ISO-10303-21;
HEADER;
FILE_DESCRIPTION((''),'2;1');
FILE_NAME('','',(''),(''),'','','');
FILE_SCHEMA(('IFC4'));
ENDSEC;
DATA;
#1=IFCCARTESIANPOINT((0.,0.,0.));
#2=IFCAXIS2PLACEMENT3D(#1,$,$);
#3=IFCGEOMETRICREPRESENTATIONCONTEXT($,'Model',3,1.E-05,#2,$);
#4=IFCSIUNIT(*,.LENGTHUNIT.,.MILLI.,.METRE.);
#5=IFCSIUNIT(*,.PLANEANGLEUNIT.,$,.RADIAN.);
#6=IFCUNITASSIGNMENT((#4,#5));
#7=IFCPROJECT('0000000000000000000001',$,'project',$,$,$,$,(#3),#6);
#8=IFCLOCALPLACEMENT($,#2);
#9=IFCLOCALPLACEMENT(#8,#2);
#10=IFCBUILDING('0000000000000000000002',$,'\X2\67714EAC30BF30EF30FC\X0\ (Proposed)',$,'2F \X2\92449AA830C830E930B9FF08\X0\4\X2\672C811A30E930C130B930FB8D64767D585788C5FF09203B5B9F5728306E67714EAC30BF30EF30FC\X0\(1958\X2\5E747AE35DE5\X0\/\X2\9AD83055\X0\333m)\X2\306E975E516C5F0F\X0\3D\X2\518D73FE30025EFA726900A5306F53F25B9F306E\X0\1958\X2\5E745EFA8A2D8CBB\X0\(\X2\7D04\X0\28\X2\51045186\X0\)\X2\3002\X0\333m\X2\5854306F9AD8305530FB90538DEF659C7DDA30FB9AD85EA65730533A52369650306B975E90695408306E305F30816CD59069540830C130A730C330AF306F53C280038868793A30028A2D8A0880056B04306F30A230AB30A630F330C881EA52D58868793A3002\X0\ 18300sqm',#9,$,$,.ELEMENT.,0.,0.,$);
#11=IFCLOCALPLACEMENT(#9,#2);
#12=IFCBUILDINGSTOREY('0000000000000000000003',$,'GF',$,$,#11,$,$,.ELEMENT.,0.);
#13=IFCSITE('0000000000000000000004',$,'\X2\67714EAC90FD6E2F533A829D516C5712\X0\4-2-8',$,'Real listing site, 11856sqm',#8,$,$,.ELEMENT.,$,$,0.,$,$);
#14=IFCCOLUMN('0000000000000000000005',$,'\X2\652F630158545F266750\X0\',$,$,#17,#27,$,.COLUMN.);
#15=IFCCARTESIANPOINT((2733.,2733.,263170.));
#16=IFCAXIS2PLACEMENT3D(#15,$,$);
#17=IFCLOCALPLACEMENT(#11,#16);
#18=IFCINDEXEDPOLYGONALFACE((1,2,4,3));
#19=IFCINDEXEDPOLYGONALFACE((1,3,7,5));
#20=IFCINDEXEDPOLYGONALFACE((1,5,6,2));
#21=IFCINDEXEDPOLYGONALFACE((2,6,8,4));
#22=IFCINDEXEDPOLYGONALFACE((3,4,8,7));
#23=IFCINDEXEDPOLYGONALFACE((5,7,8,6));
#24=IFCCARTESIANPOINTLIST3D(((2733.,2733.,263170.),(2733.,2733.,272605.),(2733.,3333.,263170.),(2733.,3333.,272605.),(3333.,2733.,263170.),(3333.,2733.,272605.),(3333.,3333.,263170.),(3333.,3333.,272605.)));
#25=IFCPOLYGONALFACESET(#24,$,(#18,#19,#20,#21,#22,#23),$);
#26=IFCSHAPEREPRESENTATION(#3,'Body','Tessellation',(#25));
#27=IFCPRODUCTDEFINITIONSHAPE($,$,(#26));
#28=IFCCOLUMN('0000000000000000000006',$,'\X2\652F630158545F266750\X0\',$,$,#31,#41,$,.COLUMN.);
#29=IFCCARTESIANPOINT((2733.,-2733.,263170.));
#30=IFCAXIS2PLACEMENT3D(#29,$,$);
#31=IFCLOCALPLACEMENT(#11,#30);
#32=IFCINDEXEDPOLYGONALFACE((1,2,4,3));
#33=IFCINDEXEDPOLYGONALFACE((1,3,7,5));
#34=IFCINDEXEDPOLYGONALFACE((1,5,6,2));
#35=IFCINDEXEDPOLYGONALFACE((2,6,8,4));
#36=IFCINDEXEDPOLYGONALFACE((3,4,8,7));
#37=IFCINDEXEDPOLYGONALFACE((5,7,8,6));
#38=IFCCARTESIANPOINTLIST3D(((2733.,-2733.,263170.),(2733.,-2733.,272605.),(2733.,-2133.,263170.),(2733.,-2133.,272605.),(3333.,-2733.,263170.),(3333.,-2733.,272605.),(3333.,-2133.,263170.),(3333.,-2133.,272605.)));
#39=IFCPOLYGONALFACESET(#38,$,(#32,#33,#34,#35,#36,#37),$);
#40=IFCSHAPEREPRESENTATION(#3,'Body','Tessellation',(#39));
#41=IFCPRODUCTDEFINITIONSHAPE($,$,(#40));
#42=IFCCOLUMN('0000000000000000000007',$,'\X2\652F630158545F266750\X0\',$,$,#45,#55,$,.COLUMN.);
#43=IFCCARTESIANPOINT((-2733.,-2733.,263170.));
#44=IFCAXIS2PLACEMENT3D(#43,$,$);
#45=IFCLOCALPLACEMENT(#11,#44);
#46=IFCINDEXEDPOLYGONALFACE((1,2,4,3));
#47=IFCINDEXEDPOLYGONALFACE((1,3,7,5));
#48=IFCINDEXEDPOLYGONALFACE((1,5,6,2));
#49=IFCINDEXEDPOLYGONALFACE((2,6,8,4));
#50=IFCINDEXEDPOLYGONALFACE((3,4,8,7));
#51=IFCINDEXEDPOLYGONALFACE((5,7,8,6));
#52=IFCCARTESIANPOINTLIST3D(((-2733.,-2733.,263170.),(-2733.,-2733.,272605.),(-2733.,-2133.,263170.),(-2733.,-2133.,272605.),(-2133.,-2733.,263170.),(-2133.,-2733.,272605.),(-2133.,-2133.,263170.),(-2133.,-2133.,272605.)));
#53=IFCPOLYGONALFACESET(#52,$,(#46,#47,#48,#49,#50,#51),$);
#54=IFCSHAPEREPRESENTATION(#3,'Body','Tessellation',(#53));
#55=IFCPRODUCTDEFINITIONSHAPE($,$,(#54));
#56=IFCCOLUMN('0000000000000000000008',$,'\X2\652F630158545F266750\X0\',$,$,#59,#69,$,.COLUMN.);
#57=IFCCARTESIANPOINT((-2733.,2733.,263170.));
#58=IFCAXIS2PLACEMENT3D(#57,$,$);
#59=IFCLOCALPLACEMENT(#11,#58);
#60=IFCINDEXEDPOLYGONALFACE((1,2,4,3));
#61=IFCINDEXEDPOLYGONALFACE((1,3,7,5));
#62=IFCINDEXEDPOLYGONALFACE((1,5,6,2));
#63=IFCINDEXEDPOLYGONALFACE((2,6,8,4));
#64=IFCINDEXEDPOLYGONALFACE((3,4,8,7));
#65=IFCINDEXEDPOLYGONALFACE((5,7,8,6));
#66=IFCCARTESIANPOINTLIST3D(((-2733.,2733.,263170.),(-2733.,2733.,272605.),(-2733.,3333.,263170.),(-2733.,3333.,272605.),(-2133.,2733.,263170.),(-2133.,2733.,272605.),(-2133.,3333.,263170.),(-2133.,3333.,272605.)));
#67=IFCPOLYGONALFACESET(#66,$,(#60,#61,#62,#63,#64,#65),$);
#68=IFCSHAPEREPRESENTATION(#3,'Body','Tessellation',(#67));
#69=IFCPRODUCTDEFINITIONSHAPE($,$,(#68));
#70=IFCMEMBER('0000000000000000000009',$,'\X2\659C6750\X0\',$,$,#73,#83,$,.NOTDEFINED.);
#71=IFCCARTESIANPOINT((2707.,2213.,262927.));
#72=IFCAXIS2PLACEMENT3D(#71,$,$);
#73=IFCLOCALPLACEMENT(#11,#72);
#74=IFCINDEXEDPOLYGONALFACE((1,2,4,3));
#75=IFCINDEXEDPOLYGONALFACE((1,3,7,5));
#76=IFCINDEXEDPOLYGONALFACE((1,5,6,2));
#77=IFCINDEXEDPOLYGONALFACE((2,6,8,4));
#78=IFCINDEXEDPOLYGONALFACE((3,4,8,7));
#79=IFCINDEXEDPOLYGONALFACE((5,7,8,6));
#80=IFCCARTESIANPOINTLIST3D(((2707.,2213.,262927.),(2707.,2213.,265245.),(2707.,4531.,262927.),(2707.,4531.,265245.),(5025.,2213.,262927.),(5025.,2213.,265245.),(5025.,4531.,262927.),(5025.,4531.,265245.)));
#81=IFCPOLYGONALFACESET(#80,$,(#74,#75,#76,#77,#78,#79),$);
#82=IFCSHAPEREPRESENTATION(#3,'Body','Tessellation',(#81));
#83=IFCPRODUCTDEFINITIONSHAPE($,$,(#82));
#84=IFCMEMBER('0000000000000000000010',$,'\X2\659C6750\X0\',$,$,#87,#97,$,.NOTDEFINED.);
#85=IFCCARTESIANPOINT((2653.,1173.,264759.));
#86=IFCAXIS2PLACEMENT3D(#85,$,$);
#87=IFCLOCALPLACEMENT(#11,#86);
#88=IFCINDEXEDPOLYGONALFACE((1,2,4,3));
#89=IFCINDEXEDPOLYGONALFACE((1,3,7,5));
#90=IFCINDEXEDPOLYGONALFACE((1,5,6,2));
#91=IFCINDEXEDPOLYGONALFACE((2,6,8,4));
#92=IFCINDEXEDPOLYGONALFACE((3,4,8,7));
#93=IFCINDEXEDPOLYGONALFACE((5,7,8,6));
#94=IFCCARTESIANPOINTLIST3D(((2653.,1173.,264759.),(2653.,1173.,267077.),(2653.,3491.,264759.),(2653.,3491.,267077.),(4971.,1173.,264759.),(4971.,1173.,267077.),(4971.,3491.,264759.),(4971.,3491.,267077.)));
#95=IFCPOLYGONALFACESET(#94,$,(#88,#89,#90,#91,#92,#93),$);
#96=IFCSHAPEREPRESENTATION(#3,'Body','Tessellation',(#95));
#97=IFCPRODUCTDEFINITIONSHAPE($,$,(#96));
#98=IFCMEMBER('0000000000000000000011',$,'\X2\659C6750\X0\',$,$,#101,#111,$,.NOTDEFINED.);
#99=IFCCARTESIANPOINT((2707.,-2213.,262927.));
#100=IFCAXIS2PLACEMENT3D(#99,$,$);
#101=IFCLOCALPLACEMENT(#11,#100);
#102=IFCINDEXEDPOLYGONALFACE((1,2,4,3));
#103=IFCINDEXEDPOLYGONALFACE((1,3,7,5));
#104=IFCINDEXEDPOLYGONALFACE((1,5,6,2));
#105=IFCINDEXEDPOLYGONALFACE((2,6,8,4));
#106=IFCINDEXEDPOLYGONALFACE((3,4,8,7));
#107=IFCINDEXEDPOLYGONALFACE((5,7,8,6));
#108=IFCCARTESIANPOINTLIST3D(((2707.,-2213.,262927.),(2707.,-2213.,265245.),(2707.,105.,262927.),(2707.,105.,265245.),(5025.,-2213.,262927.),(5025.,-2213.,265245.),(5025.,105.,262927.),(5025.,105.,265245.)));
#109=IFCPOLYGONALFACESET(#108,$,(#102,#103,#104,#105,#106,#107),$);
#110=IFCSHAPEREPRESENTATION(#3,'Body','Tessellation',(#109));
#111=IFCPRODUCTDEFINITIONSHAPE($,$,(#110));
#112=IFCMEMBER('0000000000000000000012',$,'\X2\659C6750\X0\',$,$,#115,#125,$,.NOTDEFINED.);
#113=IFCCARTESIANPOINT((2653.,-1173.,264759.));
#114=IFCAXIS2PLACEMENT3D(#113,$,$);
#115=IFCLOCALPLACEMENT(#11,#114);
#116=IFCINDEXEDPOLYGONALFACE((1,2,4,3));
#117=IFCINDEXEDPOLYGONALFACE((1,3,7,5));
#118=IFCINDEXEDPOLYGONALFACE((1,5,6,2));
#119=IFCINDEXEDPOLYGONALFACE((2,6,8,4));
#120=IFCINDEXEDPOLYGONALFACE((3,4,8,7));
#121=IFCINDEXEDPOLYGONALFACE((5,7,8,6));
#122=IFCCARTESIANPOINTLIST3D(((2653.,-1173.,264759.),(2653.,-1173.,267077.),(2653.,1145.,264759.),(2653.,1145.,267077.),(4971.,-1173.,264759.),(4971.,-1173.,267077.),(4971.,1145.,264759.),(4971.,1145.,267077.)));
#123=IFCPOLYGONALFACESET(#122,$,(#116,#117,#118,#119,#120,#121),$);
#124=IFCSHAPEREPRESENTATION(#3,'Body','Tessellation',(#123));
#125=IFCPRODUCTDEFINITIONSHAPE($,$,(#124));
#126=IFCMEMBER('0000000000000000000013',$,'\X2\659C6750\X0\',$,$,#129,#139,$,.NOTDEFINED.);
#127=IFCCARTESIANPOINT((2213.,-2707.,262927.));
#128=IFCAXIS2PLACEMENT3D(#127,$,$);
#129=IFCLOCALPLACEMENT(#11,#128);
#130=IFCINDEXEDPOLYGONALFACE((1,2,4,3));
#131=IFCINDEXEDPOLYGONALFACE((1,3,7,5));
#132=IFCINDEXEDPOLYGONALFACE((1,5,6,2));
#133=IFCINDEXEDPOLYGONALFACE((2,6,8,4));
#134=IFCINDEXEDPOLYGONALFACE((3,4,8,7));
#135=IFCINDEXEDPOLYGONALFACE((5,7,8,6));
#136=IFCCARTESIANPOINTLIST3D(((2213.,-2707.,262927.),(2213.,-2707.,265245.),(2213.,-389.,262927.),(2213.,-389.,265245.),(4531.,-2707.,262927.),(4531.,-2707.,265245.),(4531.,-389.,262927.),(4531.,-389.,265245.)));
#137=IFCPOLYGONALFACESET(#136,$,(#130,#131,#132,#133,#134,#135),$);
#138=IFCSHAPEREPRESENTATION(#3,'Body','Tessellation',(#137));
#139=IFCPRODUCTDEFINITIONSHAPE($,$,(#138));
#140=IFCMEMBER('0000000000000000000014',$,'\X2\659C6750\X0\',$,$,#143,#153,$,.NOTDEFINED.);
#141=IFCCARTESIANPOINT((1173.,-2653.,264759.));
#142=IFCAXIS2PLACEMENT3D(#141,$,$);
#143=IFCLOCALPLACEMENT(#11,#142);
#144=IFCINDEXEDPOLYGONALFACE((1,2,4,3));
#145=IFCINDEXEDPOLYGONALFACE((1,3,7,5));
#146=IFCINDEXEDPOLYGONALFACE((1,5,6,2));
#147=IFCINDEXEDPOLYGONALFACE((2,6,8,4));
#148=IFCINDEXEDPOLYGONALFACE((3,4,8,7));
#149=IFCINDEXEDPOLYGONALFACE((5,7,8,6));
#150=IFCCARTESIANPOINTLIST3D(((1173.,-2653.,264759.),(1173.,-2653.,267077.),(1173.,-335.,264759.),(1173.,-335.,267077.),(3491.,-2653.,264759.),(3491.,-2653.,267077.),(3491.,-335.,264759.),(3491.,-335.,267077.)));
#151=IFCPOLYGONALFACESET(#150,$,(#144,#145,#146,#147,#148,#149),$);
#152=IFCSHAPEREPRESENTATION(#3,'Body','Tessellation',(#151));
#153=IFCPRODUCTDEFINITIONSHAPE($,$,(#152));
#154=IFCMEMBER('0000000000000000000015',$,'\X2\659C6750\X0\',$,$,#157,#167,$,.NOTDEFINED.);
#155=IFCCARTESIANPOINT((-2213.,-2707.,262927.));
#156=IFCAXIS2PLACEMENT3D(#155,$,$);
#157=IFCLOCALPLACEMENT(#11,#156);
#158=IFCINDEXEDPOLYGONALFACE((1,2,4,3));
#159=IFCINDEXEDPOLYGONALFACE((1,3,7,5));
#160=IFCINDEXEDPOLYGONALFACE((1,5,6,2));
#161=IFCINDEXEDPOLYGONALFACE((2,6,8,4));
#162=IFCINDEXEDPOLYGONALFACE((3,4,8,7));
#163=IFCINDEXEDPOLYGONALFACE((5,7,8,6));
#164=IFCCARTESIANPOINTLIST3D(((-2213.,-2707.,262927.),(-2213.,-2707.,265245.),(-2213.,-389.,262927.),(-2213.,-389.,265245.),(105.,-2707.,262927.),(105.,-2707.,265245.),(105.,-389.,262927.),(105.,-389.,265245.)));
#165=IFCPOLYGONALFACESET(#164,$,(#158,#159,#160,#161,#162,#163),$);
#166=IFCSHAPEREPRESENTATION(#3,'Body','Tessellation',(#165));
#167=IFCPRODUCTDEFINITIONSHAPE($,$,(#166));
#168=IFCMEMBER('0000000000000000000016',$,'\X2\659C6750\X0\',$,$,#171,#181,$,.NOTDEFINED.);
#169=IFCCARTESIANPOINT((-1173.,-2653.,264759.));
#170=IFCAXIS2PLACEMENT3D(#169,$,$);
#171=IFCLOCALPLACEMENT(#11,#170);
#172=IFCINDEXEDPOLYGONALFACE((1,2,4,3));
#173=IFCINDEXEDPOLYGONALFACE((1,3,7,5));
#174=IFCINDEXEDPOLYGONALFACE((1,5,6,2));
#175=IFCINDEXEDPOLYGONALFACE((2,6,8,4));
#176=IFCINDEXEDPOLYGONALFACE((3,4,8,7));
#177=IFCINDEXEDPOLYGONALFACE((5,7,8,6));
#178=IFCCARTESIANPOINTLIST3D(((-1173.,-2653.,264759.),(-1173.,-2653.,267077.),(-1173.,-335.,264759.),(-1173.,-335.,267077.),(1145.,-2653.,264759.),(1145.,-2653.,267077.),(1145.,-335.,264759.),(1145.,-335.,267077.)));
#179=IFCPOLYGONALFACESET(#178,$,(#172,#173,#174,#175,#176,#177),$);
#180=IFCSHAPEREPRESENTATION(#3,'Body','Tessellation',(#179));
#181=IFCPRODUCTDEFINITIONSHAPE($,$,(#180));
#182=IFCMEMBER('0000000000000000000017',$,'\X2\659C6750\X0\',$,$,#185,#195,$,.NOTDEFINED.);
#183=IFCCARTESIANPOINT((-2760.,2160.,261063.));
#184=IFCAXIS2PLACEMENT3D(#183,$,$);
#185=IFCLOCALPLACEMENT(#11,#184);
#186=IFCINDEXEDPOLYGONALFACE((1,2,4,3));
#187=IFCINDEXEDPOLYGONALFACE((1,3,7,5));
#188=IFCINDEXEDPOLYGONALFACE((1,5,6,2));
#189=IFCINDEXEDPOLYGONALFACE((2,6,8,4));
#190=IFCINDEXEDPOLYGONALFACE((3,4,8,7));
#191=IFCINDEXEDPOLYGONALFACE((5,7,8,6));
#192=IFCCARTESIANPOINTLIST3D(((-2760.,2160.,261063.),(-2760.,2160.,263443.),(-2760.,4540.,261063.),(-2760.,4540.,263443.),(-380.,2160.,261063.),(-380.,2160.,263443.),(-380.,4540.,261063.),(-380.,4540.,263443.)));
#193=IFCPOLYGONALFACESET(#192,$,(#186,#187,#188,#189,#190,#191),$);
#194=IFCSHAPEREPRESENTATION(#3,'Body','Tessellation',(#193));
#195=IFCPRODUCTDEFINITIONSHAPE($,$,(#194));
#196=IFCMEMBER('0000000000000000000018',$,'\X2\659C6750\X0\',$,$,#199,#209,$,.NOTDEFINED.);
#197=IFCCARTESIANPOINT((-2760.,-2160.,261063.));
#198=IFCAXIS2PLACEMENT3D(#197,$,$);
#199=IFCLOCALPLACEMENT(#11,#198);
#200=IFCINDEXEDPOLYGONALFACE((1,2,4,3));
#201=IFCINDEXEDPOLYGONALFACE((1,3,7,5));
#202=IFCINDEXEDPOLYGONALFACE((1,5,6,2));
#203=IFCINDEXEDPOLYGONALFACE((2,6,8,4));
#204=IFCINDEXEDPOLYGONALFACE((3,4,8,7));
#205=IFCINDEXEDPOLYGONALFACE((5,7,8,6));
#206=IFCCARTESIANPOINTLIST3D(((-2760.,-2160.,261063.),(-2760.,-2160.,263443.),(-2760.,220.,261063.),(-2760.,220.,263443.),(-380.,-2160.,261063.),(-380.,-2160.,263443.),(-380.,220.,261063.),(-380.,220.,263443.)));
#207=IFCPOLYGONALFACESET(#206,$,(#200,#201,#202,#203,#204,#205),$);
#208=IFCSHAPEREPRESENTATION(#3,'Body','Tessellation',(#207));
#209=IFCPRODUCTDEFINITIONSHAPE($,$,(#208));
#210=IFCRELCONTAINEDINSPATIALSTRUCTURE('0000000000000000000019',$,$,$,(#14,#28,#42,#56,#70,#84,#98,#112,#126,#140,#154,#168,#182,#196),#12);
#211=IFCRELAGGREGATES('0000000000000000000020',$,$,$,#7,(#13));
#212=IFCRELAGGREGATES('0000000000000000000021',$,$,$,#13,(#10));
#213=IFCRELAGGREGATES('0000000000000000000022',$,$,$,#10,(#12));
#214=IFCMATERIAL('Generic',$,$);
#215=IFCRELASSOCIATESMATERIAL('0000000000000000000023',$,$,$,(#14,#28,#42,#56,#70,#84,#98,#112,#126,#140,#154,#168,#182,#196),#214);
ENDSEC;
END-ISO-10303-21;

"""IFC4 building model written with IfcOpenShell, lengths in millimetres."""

from ifc_helpers import new_model, si_unit, frame, frame_2d, origin, place, context, project, spatial, rectangle, extrude, material, element, save


model = new_model("IFC4")

# Units and contexts
model_context = context("Model", 3, precision=1e-05, world=origin())
ifc_project = project(units=[si_unit("LENGTHUNIT", "METRE", prefix="MILLI"), si_unit("PLANEANGLEUNIT", "RADIAN")], contexts=[model_context])

# Site, building, storey
site_placement = place(None, origin())
site = spatial("IfcSite", under=ifc_project, at=site_placement, Name="東京都港区芝公園4-2-8", ObjectType="Real listing site, 11856sqm", CompositionType="ELEMENT", RefElevation=0.0)
building_placement = place(site_placement, origin())
building = spatial("IfcBuilding", under=site, at=building_placement, Name="東京タワー (Proposed)", ObjectType="2F 鉄骨トラス（4本脚ラチス・赤白塗装）※実在の東京タワー(1958年竣工/高さ333m)の非公式3D再現。建物¥は史実の1958年建設費(約28億円)。333m塔は高さ・道路斜線・高度地区制限に非適合のため法適合チェックは参考表示。設計者欄はアカウント自動表示。 18300sqm", CompositionType="ELEMENT", ElevationOfRefHeight=0.0, ElevationOfTerrain=0.0)
storey_placement = place(building_placement, origin())
storey = spatial("IfcBuildingStorey", under=building, at=storey_placement, Name="GF", CompositionType="ELEMENT", Elevation=0.0)

# Columns
ifc_material = material(Name="Generic")
column_1_placement = place(storey_placement, frame((2733.0, 2733.0, 263170.0)))
element("IfcColumn", 1, at=column_1_placement, inside=storey, material=ifc_material, Name="支持塔弦材", PredefinedType="COLUMN", context=model_context, shape_type="SweptSolid", body=[
    extrude(rectangle(XDim=600.0, YDim=600.0, at=frame_2d((300.0, 300.0))), frame((2733.0, 2733.0, 263170.0)), (0.0, 0.0, 1.0), 9435.0),
])
column_2_placement = place(storey_placement, frame((2733.0, -2733.0, 263170.0)))
element("IfcColumn", 2, at=column_2_placement, inside=storey, material=ifc_material, Name="支持塔弦材", PredefinedType="COLUMN", context=model_context, shape_type="SweptSolid", body=[
    extrude(rectangle(XDim=600.0, YDim=600.0, at=frame_2d((300.0, 300.0))), frame((2733.0, -2733.0, 263170.0)), (0.0, 0.0, 1.0), 9435.0),
])
column_3_placement = place(storey_placement, frame((-2733.0, -2733.0, 263170.0)))
element("IfcColumn", 3, at=column_3_placement, inside=storey, material=ifc_material, Name="支持塔弦材", PredefinedType="COLUMN", context=model_context, shape_type="SweptSolid", body=[
    extrude(rectangle(XDim=600.0, YDim=600.0, at=frame_2d((300.0, 300.0))), frame((-2733.0, -2733.0, 263170.0)), (0.0, 0.0, 1.0), 9435.0),
])
column_4_placement = place(storey_placement, frame((-2733.0, 2733.0, 263170.0)))
element("IfcColumn", 4, at=column_4_placement, inside=storey, material=ifc_material, Name="支持塔弦材", PredefinedType="COLUMN", context=model_context, shape_type="SweptSolid", body=[
    extrude(rectangle(XDim=600.0, YDim=600.0, at=frame_2d((300.0, 300.0))), frame((-2733.0, 2733.0, 263170.0)), (0.0, 0.0, 1.0), 9435.0),
])

# Members
member_1_placement = place(storey_placement, frame((2707.0, 2213.0, 262927.0)))
element("IfcMember", 5, at=member_1_placement, inside=storey, material=ifc_material, Name="斜材", PredefinedType="NOTDEFINED", context=model_context, shape_type="SweptSolid", body=[
    extrude(rectangle(XDim=2318.0, YDim=2318.0, at=frame_2d((1159.0, 1159.0))), frame((2707.0, 2213.0, 262927.0)), (0.0, 0.0, 1.0), 2318.0),
])
member_2_placement = place(storey_placement, frame((2653.0, 1173.0, 264759.0)))
element("IfcMember", 6, at=member_2_placement, inside=storey, material=ifc_material, Name="斜材", PredefinedType="NOTDEFINED", context=model_context, shape_type="SweptSolid", body=[
    extrude(rectangle(XDim=2318.0, YDim=2318.0, at=frame_2d((1159.0, 1159.0))), frame((2653.0, 1173.0, 264759.0)), (0.0, 0.0, 1.0), 2318.0),
])
member_3_placement = place(storey_placement, frame((2707.0, -2213.0, 262927.0)))
element("IfcMember", 7, at=member_3_placement, inside=storey, material=ifc_material, Name="斜材", PredefinedType="NOTDEFINED", context=model_context, shape_type="SweptSolid", body=[
    extrude(rectangle(XDim=2318.0, YDim=2318.0, at=frame_2d((1159.0, 1159.0))), frame((2707.0, -2213.0, 262927.0)), (0.0, 0.0, 1.0), 2318.0),
])
member_4_placement = place(storey_placement, frame((2653.0, -1173.0, 264759.0)))
element("IfcMember", 8, at=member_4_placement, inside=storey, material=ifc_material, Name="斜材", PredefinedType="NOTDEFINED", context=model_context, shape_type="SweptSolid", body=[
    extrude(rectangle(XDim=2318.0, YDim=2318.0, at=frame_2d((1159.0, 1159.0))), frame((2653.0, -1173.0, 264759.0)), (0.0, 0.0, 1.0), 2318.0),
])
member_5_placement = place(storey_placement, frame((2213.0, -2707.0, 262927.0)))
element("IfcMember", 9, at=member_5_placement, inside=storey, material=ifc_material, Name="斜材", PredefinedType="NOTDEFINED", context=model_context, shape_type="SweptSolid", body=[
    extrude(rectangle(XDim=2318.0, YDim=2318.0, at=frame_2d((1159.0, 1159.0))), frame((2213.0, -2707.0, 262927.0)), (0.0, 0.0, 1.0), 2318.0),
])
member_6_placement = place(storey_placement, frame((1173.0, -2653.0, 264759.0)))
element("IfcMember", 10, at=member_6_placement, inside=storey, material=ifc_material, Name="斜材", PredefinedType="NOTDEFINED", context=model_context, shape_type="SweptSolid", body=[
    extrude(rectangle(XDim=2318.0, YDim=2318.0, at=frame_2d((1159.0, 1159.0))), frame((1173.0, -2653.0, 264759.0)), (0.0, 0.0, 1.0), 2318.0),
])
member_7_placement = place(storey_placement, frame((-2213.0, -2707.0, 262927.0)))
element("IfcMember", 11, at=member_7_placement, inside=storey, material=ifc_material, Name="斜材", PredefinedType="NOTDEFINED", context=model_context, shape_type="SweptSolid", body=[
    extrude(rectangle(XDim=2318.0, YDim=2318.0, at=frame_2d((1159.0, 1159.0))), frame((-2213.0, -2707.0, 262927.0)), (0.0, 0.0, 1.0), 2318.0),
])
member_8_placement = place(storey_placement, frame((-1173.0, -2653.0, 264759.0)))
element("IfcMember", 12, at=member_8_placement, inside=storey, material=ifc_material, Name="斜材", PredefinedType="NOTDEFINED", context=model_context, shape_type="SweptSolid", body=[
    extrude(rectangle(XDim=2318.0, YDim=2318.0, at=frame_2d((1159.0, 1159.0))), frame((-1173.0, -2653.0, 264759.0)), (0.0, 0.0, 1.0), 2318.0),
])
member_9_placement = place(storey_placement, frame((-2760.0, 2160.0, 261063.0)))
element("IfcMember", 13, at=member_9_placement, inside=storey, material=ifc_material, Name="斜材", PredefinedType="NOTDEFINED", context=model_context, shape_type="SweptSolid", body=[
    extrude(rectangle(XDim=2380.0, YDim=2380.0, at=frame_2d((1190.0, 1190.0))), frame((-2760.0, 2160.0, 261063.0)), (0.0, 0.0, 1.0), 2380.0),
])
member_10_placement = place(storey_placement, frame((-2760.0, -2160.0, 261063.0)))
element("IfcMember", 14, at=member_10_placement, inside=storey, material=ifc_material, Name="斜材", PredefinedType="NOTDEFINED", context=model_context, shape_type="SweptSolid", body=[
    extrude(rectangle(XDim=2380.0, YDim=2380.0, at=frame_2d((1190.0, 1190.0))), frame((-2760.0, -2160.0, 261063.0)), (0.0, 0.0, 1.0), 2380.0),
])

save(model, "model.ifc")
